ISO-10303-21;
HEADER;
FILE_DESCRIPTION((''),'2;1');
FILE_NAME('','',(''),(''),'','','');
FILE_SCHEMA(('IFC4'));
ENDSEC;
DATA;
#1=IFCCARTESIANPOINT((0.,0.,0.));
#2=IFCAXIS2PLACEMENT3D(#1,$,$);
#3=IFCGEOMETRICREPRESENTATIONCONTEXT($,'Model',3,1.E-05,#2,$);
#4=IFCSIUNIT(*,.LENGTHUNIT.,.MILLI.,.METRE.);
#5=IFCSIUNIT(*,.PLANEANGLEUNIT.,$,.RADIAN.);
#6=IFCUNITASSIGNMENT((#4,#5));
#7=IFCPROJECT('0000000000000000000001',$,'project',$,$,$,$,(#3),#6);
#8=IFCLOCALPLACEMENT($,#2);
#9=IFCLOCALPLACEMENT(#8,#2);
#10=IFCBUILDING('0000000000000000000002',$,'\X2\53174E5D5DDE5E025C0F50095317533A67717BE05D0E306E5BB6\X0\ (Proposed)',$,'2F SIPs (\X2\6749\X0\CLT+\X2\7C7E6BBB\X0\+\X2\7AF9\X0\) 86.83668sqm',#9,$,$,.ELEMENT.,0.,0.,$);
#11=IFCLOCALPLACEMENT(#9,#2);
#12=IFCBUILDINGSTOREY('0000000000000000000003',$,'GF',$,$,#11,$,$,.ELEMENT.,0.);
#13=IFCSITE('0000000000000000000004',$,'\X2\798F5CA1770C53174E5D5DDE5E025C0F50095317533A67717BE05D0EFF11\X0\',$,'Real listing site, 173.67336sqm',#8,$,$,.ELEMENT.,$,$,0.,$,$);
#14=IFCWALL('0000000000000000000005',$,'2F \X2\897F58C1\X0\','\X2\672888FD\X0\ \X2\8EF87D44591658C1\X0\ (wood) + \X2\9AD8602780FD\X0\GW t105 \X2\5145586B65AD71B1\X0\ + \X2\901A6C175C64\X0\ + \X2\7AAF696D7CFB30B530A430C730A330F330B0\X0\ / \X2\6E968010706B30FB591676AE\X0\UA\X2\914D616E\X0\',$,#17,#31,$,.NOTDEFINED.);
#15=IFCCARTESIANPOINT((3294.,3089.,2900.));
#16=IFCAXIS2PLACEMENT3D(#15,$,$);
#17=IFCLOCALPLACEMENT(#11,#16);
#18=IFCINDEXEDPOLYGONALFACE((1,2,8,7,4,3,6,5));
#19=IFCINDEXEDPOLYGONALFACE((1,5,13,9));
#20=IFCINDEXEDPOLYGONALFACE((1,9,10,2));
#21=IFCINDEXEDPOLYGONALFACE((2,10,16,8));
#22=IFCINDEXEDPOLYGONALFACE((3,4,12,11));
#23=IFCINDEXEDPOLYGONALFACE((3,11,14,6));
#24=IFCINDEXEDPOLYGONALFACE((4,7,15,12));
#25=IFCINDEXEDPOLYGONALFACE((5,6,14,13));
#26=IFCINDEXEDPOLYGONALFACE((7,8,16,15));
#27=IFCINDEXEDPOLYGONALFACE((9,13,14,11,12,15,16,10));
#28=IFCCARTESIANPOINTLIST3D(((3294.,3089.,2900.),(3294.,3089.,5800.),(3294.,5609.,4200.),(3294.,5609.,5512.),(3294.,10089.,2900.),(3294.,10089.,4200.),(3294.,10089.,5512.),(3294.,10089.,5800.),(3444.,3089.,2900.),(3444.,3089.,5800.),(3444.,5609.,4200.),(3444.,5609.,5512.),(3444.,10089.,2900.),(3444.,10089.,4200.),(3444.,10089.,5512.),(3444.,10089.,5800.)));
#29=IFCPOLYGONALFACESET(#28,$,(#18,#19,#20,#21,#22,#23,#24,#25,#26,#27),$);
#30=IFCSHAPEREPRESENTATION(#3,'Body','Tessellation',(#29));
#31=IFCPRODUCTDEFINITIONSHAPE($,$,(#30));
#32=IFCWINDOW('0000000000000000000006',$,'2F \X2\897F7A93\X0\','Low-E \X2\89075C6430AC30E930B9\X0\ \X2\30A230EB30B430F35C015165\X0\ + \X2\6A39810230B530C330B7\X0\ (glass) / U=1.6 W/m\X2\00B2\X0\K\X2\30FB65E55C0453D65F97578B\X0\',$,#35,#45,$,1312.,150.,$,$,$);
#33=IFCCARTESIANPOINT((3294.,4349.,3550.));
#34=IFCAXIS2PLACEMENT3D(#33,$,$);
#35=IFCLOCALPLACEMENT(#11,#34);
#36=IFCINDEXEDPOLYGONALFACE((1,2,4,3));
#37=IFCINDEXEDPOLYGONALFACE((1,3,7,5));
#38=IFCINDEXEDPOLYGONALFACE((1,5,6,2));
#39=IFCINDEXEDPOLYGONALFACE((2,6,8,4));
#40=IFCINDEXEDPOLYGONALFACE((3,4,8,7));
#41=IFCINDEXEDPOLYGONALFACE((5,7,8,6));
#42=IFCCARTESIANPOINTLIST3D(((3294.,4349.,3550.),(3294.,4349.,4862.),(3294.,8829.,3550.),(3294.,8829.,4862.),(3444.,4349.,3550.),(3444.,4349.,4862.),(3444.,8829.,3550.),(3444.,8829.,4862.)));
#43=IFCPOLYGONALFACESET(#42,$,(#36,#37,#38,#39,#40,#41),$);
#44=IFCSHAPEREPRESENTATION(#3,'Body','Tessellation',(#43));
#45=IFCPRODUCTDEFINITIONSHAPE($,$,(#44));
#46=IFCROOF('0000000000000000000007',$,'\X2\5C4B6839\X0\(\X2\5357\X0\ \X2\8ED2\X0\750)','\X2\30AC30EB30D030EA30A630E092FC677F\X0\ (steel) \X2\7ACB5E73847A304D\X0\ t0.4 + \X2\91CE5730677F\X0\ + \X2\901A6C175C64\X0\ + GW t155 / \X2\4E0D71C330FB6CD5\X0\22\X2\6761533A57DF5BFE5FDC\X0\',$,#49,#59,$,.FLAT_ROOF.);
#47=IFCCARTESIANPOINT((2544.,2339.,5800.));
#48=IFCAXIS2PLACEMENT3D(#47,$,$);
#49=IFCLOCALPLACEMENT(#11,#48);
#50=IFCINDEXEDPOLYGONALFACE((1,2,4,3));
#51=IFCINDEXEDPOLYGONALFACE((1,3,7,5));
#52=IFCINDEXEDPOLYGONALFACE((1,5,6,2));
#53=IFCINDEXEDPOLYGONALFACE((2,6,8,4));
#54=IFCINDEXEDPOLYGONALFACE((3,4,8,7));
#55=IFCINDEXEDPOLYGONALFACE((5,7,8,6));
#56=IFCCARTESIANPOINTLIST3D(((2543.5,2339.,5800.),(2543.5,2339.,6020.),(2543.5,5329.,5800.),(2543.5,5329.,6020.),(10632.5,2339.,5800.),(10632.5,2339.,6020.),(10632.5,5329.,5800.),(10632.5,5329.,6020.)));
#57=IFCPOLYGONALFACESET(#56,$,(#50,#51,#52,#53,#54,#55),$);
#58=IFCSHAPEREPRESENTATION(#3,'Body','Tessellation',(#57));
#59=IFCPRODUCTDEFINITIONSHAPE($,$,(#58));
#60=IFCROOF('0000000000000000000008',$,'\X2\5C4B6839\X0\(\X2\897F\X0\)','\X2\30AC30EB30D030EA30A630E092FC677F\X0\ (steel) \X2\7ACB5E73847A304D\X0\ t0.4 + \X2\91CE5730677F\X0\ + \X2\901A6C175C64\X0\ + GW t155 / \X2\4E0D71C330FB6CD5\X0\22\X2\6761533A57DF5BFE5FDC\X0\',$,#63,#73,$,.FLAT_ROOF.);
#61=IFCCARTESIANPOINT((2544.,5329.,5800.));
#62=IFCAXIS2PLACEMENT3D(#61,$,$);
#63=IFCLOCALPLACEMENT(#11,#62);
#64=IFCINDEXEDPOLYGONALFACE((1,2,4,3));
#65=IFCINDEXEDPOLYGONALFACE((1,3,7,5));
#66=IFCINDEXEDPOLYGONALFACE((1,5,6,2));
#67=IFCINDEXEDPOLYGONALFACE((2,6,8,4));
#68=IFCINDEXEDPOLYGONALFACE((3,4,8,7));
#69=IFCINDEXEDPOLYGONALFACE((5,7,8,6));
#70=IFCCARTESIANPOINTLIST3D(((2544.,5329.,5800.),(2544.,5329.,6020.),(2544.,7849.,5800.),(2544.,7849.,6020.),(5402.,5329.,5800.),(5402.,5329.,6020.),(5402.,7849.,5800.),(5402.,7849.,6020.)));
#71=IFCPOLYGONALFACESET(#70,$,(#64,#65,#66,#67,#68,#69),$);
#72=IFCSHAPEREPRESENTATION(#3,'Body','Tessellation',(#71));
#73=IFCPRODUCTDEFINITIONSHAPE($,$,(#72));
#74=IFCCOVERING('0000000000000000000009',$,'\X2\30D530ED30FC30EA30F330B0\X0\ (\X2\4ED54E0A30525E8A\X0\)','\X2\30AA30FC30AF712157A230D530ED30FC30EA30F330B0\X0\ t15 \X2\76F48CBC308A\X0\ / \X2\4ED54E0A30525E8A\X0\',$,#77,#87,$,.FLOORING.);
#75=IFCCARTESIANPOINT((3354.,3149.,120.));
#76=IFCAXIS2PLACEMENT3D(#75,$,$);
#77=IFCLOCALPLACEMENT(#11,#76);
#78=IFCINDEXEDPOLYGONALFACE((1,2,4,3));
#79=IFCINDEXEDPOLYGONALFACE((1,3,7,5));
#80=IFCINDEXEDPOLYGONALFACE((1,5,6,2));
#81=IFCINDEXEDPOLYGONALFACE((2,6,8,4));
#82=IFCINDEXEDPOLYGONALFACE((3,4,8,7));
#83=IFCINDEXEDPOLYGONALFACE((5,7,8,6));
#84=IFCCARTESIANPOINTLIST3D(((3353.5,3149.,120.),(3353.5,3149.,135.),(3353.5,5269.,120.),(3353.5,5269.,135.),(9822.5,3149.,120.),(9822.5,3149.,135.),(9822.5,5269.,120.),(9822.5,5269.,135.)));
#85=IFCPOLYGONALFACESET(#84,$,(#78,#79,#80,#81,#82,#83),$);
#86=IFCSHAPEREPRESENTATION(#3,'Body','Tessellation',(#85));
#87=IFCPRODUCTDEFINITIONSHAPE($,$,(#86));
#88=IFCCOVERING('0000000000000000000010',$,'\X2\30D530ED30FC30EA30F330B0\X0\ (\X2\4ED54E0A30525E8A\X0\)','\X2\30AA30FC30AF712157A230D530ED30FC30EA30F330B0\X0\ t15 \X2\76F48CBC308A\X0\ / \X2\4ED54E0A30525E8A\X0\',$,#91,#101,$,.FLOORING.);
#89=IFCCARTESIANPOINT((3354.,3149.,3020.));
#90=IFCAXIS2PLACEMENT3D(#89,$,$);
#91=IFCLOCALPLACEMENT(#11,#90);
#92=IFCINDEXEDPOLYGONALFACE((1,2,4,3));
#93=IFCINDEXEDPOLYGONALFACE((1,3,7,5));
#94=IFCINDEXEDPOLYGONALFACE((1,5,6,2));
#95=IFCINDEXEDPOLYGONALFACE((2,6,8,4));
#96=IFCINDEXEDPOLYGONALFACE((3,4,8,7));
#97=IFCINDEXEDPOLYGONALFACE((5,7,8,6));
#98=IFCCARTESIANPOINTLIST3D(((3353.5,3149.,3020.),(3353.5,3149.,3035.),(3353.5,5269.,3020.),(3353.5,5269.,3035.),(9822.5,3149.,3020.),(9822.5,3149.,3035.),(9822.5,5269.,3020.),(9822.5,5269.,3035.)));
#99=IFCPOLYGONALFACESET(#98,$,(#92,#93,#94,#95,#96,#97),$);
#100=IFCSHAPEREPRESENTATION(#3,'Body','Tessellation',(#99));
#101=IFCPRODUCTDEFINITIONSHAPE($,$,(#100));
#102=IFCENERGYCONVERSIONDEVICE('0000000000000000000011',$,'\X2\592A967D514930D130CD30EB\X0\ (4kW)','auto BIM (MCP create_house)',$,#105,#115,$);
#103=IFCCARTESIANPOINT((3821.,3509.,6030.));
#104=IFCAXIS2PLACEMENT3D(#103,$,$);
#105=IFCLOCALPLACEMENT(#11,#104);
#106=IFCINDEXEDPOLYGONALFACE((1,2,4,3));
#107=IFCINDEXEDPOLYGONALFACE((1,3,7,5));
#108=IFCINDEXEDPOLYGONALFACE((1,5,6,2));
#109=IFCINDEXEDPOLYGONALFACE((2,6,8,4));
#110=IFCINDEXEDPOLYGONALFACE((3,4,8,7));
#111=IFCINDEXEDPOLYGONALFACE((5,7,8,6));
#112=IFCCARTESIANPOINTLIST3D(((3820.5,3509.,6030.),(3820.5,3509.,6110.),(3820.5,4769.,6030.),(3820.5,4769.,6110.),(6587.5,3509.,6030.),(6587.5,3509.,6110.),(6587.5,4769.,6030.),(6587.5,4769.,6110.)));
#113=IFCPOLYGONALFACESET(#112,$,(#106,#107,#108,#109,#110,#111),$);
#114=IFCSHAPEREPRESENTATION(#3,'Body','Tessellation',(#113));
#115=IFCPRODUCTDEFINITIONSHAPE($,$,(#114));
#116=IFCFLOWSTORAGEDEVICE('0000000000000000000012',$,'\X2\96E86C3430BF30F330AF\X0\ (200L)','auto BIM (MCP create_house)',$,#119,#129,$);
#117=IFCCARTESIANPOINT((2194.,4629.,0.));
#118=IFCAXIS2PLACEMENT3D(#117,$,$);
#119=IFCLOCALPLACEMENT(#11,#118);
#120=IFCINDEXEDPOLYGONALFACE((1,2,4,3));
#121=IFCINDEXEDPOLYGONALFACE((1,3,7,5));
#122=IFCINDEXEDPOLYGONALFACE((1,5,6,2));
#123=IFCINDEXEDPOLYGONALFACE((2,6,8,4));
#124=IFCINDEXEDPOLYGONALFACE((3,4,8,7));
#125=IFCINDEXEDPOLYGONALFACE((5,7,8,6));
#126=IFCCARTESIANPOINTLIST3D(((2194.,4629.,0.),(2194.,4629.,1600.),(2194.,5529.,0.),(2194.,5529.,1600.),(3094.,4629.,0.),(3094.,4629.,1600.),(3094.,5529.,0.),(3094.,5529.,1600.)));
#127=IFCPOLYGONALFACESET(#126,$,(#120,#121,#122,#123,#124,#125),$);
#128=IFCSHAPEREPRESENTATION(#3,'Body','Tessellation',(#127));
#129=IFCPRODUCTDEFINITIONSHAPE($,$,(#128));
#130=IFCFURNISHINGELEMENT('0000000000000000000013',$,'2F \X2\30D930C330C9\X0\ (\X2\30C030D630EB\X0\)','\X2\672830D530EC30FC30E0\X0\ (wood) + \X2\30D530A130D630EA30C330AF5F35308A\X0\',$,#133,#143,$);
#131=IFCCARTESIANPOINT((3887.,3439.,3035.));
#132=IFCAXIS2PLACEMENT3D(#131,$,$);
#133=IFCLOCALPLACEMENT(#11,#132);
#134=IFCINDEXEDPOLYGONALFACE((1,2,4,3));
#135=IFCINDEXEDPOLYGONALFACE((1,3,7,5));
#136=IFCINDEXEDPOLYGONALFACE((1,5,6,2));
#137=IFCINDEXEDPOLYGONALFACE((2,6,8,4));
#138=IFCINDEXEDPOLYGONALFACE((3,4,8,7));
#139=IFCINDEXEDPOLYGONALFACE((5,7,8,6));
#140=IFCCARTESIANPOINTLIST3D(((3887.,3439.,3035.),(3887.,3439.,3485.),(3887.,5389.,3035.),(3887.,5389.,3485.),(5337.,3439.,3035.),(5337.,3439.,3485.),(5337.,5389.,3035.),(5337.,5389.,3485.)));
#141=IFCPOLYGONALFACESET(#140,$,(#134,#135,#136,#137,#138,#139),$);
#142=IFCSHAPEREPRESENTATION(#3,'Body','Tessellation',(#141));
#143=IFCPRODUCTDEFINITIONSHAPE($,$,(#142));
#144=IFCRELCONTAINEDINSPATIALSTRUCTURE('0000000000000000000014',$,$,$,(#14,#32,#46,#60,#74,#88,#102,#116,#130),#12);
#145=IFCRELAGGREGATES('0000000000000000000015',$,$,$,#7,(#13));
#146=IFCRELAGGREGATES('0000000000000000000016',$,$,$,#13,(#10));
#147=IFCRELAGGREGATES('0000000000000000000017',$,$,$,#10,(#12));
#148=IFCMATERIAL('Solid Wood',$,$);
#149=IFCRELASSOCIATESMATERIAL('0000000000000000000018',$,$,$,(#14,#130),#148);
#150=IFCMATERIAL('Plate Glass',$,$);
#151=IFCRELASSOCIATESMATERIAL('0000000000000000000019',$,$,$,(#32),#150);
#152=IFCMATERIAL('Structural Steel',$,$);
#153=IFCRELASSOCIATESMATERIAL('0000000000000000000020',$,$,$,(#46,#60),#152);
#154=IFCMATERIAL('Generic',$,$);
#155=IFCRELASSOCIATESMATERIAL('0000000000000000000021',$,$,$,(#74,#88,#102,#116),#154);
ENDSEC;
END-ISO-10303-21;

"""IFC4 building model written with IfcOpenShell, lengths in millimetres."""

from ifc_helpers import new_model, si_unit, frame, frame_2d, origin, place, context, project, spatial, rectangle, extrude, material, element, fill, save


model = new_model("IFC4")

# Units and contexts
model_context = context("Model", 3, precision=1e-05, world=origin())
ifc_project = project(units=[si_unit("LENGTHUNIT", "METRE", prefix="MILLI"), si_unit("PLANEANGLEUNIT", "RADIAN")], contexts=[model_context])

# Site, building, storey
site_placement = place(None, origin())
site = spatial("IfcSite", under=ifc_project, at=site_placement, Name="福岡県北九州市小倉北区東篠崎１", ObjectType="Real listing site, 173.67336sqm", CompositionType="ELEMENT", RefElevation=0.0)
building_placement = place(site_placement, origin())
building = spatial("IfcBuilding", under=site, at=building_placement, Name="北九州市小倉北区東篠崎の家 (Proposed)", ObjectType="2F SIPs (杉CLT+籾殻+竹) 86.83668sqm", CompositionType="ELEMENT", ElevationOfRefHeight=0.0, ElevationOfTerrain=0.0)
storey_placement = place(building_placement, origin())
storey = spatial("IfcBuildingStorey", under=building, at=storey_placement, Name="GF", CompositionType="ELEMENT", Elevation=0.0)

# Shared definitions
ifc_material_1 = material(Name="Solid Wood")

# Shared definitions
ifc_material_2 = material(Name="Plate Glass")

# Wall, opening, window
wall_1_placement = place(storey_placement, frame((3294.0, 3089.0, 2900.0)))
wall_1 = element("IfcWall", 1, at=wall_1_placement, inside=storey, material=ifc_material_1, Name="2F 西壁", Description="木製 軸組外壁 (wood) + 高性能GW t105 充填断熱 + 通気層 + 窯業系サイディング / 準耐火・外皮UA配慮", PredefinedType="NOTDEFINED", context=model_context, shape_type="SweptSolid", body=[
    extrude(rectangle(XDim=150.0, YDim=7000.0, at=frame_2d((75.0, 3500.0))), frame((3294.0, 3089.0, 2900.0)), (0.0, 0.0, 1.0), 2900.0),
])
opening_1_placement = place(storey_placement, frame((3294.0, 4349.0, 3550.0)))
opening_1 = element("IfcOpeningElement", 2, at=opening_1_placement, cuts=wall_1, PredefinedType="NOTDEFINED", context=model_context, shape_type="SweptSolid", body=[
    extrude(rectangle(XDim=150.0, YDim=4480.0, at=frame_2d((75.0, 2240.0))), frame((3294.0, 4349.0, 3550.0)), (0.0, 0.0, 1.0), 1312.0),
])
window_1_placement = place(storey_placement, frame((3294.0, 4349.0, 3550.0)))
window_1 = element("IfcWindow", 3, at=window_1_placement, inside=storey, material=ifc_material_2, Name="2F 西窓", Description="Low-E 複層ガラス アルゴン封入 + 樹脂サッシ (glass) / U=1.6 W/m²K・日射取得型", OverallHeight=1312.0, OverallWidth=150.0, context=model_context, shape_type="SweptSolid", body=[
    extrude(rectangle(XDim=150.0, YDim=4480.0, at=frame_2d((75.0, 2240.0))), frame((3294.0, 4349.0, 3550.0)), (0.0, 0.0, 1.0), 1312.0),
])
fill(opening_1, window_1)

# Roofs
ifc_material_3 = material(Name="Structural Steel")
roof_1_placement = place(storey_placement, frame((2544.0, 2339.0, 5800.0)))
element("IfcRoof", 4, at=roof_1_placement, inside=storey, material=ifc_material_3, Name="屋根(南 軒750)", Description="ガルバリウム鋼板 (steel) 立平葺き t0.4 + 野地板 + 通気層 + GW t155 / 不燃・法22条区域対応", PredefinedType="FLAT_ROOF", context=model_context, shape_type="SweptSolid", body=[
    extrude(rectangle(XDim=8089.0, YDim=2990.0, at=frame_2d((4044.0, 1495.0))), frame((2544.0, 2339.0, 5800.0)), (0.0, 0.0, 1.0), 220.0),
])
roof_2_placement = place(storey_placement, frame((2544.0, 5329.0, 5800.0)))
element("IfcRoof", 5, at=roof_2_placement, inside=storey, material=ifc_material_3, Name="屋根(西)", Description="ガルバリウム鋼板 (steel) 立平葺き t0.4 + 野地板 + 通気層 + GW t155 / 不燃・法22条区域対応", PredefinedType="FLAT_ROOF", context=model_context, shape_type="SweptSolid", body=[
    extrude(rectangle(XDim=2858.0, YDim=2520.0, at=frame_2d((1429.0, 1260.0))), frame((2544.0, 5329.0, 5800.0)), (0.0, 0.0, 1.0), 220.0),
])

# Coverings
ifc_material_4 = material(Name="Generic")
covering_1_placement = place(storey_placement, frame((3354.0, 3149.0, 120.0)))
element("IfcCovering", 6, at=covering_1_placement, inside=storey, material=ifc_material_4, Name="フローリング (仕上げ床)", Description="オーク無垢フローリング t15 直貼り / 仕上げ床", PredefinedType="FLOORING", context=model_context, shape_type="SweptSolid", body=[
    extrude(rectangle(XDim=6469.0, YDim=2120.0, at=frame_2d((3234.0, 1060.0))), frame((3354.0, 3149.0, 120.0)), (0.0, 0.0, 1.0), 15.0),
])
covering_2_placement = place(storey_placement, frame((3354.0, 3149.0, 3020.0)))
element("IfcCovering", 7, at=covering_2_placement, inside=storey, material=ifc_material_4, Name="フローリング (仕上げ床)", Description="オーク無垢フローリング t15 直貼り / 仕上げ床", PredefinedType="FLOORING", context=model_context, shape_type="SweptSolid", body=[
    extrude(rectangle(XDim=6469.0, YDim=2120.0, at=frame_2d((3234.0, 1060.0))), frame((3354.0, 3149.0, 3020.0)), (0.0, 0.0, 1.0), 15.0),
])

# Energy conversion device
energy_conversion_device_placement = place(storey_placement, frame((3821.0, 3509.0, 6030.0)))
element("IfcEnergyConversionDevice", 8, at=energy_conversion_device_placement, inside=storey, material=ifc_material_4, Name="太陽光パネル (4kW)", Description="auto BIM (MCP create_house)", context=model_context, shape_type="SweptSolid", body=[
    extrude(rectangle(XDim=2767.0, YDim=1260.0, at=frame_2d((1383.0, 630.0))), frame((3821.0, 3509.0, 6030.0)), (0.0, 0.0, 1.0), 80.0),
])

# Flow storage device
flow_storage_device_placement = place(storey_placement, frame((2194.0, 4629.0, 0.0)))
element("IfcFlowStorageDevice", 9, at=flow_storage_device_placement, inside=storey, material=ifc_material_4, Name="雨水タンク (200L)", Description="auto BIM (MCP create_house)", context=model_context, shape_type="SweptSolid", body=[
    extrude(rectangle(XDim=900.0, YDim=900.0, at=frame_2d((450.0, 450.0))), frame((2194.0, 4629.0, 0.0)), (0.0, 0.0, 1.0), 1600.0),
])

# Furnishing element
furnishing_placement = place(storey_placement, frame((3887.0, 3439.0, 3035.0)))
element("IfcFurnishingElement", 10, at=furnishing_placement, inside=storey, material=ifc_material_1, Name="2F ベッド (ダブル)", Description="木フレーム (wood) + ファブリック張り", context=model_context, shape_type="SweptSolid", body=[
    extrude(rectangle(XDim=1450.0, YDim=1950.0, at=frame_2d((725.0, 975.0))), frame((3887.0, 3439.0, 3035.0)), (0.0, 0.0, 1.0), 450.0),
])

save(model, "model.ifc")
